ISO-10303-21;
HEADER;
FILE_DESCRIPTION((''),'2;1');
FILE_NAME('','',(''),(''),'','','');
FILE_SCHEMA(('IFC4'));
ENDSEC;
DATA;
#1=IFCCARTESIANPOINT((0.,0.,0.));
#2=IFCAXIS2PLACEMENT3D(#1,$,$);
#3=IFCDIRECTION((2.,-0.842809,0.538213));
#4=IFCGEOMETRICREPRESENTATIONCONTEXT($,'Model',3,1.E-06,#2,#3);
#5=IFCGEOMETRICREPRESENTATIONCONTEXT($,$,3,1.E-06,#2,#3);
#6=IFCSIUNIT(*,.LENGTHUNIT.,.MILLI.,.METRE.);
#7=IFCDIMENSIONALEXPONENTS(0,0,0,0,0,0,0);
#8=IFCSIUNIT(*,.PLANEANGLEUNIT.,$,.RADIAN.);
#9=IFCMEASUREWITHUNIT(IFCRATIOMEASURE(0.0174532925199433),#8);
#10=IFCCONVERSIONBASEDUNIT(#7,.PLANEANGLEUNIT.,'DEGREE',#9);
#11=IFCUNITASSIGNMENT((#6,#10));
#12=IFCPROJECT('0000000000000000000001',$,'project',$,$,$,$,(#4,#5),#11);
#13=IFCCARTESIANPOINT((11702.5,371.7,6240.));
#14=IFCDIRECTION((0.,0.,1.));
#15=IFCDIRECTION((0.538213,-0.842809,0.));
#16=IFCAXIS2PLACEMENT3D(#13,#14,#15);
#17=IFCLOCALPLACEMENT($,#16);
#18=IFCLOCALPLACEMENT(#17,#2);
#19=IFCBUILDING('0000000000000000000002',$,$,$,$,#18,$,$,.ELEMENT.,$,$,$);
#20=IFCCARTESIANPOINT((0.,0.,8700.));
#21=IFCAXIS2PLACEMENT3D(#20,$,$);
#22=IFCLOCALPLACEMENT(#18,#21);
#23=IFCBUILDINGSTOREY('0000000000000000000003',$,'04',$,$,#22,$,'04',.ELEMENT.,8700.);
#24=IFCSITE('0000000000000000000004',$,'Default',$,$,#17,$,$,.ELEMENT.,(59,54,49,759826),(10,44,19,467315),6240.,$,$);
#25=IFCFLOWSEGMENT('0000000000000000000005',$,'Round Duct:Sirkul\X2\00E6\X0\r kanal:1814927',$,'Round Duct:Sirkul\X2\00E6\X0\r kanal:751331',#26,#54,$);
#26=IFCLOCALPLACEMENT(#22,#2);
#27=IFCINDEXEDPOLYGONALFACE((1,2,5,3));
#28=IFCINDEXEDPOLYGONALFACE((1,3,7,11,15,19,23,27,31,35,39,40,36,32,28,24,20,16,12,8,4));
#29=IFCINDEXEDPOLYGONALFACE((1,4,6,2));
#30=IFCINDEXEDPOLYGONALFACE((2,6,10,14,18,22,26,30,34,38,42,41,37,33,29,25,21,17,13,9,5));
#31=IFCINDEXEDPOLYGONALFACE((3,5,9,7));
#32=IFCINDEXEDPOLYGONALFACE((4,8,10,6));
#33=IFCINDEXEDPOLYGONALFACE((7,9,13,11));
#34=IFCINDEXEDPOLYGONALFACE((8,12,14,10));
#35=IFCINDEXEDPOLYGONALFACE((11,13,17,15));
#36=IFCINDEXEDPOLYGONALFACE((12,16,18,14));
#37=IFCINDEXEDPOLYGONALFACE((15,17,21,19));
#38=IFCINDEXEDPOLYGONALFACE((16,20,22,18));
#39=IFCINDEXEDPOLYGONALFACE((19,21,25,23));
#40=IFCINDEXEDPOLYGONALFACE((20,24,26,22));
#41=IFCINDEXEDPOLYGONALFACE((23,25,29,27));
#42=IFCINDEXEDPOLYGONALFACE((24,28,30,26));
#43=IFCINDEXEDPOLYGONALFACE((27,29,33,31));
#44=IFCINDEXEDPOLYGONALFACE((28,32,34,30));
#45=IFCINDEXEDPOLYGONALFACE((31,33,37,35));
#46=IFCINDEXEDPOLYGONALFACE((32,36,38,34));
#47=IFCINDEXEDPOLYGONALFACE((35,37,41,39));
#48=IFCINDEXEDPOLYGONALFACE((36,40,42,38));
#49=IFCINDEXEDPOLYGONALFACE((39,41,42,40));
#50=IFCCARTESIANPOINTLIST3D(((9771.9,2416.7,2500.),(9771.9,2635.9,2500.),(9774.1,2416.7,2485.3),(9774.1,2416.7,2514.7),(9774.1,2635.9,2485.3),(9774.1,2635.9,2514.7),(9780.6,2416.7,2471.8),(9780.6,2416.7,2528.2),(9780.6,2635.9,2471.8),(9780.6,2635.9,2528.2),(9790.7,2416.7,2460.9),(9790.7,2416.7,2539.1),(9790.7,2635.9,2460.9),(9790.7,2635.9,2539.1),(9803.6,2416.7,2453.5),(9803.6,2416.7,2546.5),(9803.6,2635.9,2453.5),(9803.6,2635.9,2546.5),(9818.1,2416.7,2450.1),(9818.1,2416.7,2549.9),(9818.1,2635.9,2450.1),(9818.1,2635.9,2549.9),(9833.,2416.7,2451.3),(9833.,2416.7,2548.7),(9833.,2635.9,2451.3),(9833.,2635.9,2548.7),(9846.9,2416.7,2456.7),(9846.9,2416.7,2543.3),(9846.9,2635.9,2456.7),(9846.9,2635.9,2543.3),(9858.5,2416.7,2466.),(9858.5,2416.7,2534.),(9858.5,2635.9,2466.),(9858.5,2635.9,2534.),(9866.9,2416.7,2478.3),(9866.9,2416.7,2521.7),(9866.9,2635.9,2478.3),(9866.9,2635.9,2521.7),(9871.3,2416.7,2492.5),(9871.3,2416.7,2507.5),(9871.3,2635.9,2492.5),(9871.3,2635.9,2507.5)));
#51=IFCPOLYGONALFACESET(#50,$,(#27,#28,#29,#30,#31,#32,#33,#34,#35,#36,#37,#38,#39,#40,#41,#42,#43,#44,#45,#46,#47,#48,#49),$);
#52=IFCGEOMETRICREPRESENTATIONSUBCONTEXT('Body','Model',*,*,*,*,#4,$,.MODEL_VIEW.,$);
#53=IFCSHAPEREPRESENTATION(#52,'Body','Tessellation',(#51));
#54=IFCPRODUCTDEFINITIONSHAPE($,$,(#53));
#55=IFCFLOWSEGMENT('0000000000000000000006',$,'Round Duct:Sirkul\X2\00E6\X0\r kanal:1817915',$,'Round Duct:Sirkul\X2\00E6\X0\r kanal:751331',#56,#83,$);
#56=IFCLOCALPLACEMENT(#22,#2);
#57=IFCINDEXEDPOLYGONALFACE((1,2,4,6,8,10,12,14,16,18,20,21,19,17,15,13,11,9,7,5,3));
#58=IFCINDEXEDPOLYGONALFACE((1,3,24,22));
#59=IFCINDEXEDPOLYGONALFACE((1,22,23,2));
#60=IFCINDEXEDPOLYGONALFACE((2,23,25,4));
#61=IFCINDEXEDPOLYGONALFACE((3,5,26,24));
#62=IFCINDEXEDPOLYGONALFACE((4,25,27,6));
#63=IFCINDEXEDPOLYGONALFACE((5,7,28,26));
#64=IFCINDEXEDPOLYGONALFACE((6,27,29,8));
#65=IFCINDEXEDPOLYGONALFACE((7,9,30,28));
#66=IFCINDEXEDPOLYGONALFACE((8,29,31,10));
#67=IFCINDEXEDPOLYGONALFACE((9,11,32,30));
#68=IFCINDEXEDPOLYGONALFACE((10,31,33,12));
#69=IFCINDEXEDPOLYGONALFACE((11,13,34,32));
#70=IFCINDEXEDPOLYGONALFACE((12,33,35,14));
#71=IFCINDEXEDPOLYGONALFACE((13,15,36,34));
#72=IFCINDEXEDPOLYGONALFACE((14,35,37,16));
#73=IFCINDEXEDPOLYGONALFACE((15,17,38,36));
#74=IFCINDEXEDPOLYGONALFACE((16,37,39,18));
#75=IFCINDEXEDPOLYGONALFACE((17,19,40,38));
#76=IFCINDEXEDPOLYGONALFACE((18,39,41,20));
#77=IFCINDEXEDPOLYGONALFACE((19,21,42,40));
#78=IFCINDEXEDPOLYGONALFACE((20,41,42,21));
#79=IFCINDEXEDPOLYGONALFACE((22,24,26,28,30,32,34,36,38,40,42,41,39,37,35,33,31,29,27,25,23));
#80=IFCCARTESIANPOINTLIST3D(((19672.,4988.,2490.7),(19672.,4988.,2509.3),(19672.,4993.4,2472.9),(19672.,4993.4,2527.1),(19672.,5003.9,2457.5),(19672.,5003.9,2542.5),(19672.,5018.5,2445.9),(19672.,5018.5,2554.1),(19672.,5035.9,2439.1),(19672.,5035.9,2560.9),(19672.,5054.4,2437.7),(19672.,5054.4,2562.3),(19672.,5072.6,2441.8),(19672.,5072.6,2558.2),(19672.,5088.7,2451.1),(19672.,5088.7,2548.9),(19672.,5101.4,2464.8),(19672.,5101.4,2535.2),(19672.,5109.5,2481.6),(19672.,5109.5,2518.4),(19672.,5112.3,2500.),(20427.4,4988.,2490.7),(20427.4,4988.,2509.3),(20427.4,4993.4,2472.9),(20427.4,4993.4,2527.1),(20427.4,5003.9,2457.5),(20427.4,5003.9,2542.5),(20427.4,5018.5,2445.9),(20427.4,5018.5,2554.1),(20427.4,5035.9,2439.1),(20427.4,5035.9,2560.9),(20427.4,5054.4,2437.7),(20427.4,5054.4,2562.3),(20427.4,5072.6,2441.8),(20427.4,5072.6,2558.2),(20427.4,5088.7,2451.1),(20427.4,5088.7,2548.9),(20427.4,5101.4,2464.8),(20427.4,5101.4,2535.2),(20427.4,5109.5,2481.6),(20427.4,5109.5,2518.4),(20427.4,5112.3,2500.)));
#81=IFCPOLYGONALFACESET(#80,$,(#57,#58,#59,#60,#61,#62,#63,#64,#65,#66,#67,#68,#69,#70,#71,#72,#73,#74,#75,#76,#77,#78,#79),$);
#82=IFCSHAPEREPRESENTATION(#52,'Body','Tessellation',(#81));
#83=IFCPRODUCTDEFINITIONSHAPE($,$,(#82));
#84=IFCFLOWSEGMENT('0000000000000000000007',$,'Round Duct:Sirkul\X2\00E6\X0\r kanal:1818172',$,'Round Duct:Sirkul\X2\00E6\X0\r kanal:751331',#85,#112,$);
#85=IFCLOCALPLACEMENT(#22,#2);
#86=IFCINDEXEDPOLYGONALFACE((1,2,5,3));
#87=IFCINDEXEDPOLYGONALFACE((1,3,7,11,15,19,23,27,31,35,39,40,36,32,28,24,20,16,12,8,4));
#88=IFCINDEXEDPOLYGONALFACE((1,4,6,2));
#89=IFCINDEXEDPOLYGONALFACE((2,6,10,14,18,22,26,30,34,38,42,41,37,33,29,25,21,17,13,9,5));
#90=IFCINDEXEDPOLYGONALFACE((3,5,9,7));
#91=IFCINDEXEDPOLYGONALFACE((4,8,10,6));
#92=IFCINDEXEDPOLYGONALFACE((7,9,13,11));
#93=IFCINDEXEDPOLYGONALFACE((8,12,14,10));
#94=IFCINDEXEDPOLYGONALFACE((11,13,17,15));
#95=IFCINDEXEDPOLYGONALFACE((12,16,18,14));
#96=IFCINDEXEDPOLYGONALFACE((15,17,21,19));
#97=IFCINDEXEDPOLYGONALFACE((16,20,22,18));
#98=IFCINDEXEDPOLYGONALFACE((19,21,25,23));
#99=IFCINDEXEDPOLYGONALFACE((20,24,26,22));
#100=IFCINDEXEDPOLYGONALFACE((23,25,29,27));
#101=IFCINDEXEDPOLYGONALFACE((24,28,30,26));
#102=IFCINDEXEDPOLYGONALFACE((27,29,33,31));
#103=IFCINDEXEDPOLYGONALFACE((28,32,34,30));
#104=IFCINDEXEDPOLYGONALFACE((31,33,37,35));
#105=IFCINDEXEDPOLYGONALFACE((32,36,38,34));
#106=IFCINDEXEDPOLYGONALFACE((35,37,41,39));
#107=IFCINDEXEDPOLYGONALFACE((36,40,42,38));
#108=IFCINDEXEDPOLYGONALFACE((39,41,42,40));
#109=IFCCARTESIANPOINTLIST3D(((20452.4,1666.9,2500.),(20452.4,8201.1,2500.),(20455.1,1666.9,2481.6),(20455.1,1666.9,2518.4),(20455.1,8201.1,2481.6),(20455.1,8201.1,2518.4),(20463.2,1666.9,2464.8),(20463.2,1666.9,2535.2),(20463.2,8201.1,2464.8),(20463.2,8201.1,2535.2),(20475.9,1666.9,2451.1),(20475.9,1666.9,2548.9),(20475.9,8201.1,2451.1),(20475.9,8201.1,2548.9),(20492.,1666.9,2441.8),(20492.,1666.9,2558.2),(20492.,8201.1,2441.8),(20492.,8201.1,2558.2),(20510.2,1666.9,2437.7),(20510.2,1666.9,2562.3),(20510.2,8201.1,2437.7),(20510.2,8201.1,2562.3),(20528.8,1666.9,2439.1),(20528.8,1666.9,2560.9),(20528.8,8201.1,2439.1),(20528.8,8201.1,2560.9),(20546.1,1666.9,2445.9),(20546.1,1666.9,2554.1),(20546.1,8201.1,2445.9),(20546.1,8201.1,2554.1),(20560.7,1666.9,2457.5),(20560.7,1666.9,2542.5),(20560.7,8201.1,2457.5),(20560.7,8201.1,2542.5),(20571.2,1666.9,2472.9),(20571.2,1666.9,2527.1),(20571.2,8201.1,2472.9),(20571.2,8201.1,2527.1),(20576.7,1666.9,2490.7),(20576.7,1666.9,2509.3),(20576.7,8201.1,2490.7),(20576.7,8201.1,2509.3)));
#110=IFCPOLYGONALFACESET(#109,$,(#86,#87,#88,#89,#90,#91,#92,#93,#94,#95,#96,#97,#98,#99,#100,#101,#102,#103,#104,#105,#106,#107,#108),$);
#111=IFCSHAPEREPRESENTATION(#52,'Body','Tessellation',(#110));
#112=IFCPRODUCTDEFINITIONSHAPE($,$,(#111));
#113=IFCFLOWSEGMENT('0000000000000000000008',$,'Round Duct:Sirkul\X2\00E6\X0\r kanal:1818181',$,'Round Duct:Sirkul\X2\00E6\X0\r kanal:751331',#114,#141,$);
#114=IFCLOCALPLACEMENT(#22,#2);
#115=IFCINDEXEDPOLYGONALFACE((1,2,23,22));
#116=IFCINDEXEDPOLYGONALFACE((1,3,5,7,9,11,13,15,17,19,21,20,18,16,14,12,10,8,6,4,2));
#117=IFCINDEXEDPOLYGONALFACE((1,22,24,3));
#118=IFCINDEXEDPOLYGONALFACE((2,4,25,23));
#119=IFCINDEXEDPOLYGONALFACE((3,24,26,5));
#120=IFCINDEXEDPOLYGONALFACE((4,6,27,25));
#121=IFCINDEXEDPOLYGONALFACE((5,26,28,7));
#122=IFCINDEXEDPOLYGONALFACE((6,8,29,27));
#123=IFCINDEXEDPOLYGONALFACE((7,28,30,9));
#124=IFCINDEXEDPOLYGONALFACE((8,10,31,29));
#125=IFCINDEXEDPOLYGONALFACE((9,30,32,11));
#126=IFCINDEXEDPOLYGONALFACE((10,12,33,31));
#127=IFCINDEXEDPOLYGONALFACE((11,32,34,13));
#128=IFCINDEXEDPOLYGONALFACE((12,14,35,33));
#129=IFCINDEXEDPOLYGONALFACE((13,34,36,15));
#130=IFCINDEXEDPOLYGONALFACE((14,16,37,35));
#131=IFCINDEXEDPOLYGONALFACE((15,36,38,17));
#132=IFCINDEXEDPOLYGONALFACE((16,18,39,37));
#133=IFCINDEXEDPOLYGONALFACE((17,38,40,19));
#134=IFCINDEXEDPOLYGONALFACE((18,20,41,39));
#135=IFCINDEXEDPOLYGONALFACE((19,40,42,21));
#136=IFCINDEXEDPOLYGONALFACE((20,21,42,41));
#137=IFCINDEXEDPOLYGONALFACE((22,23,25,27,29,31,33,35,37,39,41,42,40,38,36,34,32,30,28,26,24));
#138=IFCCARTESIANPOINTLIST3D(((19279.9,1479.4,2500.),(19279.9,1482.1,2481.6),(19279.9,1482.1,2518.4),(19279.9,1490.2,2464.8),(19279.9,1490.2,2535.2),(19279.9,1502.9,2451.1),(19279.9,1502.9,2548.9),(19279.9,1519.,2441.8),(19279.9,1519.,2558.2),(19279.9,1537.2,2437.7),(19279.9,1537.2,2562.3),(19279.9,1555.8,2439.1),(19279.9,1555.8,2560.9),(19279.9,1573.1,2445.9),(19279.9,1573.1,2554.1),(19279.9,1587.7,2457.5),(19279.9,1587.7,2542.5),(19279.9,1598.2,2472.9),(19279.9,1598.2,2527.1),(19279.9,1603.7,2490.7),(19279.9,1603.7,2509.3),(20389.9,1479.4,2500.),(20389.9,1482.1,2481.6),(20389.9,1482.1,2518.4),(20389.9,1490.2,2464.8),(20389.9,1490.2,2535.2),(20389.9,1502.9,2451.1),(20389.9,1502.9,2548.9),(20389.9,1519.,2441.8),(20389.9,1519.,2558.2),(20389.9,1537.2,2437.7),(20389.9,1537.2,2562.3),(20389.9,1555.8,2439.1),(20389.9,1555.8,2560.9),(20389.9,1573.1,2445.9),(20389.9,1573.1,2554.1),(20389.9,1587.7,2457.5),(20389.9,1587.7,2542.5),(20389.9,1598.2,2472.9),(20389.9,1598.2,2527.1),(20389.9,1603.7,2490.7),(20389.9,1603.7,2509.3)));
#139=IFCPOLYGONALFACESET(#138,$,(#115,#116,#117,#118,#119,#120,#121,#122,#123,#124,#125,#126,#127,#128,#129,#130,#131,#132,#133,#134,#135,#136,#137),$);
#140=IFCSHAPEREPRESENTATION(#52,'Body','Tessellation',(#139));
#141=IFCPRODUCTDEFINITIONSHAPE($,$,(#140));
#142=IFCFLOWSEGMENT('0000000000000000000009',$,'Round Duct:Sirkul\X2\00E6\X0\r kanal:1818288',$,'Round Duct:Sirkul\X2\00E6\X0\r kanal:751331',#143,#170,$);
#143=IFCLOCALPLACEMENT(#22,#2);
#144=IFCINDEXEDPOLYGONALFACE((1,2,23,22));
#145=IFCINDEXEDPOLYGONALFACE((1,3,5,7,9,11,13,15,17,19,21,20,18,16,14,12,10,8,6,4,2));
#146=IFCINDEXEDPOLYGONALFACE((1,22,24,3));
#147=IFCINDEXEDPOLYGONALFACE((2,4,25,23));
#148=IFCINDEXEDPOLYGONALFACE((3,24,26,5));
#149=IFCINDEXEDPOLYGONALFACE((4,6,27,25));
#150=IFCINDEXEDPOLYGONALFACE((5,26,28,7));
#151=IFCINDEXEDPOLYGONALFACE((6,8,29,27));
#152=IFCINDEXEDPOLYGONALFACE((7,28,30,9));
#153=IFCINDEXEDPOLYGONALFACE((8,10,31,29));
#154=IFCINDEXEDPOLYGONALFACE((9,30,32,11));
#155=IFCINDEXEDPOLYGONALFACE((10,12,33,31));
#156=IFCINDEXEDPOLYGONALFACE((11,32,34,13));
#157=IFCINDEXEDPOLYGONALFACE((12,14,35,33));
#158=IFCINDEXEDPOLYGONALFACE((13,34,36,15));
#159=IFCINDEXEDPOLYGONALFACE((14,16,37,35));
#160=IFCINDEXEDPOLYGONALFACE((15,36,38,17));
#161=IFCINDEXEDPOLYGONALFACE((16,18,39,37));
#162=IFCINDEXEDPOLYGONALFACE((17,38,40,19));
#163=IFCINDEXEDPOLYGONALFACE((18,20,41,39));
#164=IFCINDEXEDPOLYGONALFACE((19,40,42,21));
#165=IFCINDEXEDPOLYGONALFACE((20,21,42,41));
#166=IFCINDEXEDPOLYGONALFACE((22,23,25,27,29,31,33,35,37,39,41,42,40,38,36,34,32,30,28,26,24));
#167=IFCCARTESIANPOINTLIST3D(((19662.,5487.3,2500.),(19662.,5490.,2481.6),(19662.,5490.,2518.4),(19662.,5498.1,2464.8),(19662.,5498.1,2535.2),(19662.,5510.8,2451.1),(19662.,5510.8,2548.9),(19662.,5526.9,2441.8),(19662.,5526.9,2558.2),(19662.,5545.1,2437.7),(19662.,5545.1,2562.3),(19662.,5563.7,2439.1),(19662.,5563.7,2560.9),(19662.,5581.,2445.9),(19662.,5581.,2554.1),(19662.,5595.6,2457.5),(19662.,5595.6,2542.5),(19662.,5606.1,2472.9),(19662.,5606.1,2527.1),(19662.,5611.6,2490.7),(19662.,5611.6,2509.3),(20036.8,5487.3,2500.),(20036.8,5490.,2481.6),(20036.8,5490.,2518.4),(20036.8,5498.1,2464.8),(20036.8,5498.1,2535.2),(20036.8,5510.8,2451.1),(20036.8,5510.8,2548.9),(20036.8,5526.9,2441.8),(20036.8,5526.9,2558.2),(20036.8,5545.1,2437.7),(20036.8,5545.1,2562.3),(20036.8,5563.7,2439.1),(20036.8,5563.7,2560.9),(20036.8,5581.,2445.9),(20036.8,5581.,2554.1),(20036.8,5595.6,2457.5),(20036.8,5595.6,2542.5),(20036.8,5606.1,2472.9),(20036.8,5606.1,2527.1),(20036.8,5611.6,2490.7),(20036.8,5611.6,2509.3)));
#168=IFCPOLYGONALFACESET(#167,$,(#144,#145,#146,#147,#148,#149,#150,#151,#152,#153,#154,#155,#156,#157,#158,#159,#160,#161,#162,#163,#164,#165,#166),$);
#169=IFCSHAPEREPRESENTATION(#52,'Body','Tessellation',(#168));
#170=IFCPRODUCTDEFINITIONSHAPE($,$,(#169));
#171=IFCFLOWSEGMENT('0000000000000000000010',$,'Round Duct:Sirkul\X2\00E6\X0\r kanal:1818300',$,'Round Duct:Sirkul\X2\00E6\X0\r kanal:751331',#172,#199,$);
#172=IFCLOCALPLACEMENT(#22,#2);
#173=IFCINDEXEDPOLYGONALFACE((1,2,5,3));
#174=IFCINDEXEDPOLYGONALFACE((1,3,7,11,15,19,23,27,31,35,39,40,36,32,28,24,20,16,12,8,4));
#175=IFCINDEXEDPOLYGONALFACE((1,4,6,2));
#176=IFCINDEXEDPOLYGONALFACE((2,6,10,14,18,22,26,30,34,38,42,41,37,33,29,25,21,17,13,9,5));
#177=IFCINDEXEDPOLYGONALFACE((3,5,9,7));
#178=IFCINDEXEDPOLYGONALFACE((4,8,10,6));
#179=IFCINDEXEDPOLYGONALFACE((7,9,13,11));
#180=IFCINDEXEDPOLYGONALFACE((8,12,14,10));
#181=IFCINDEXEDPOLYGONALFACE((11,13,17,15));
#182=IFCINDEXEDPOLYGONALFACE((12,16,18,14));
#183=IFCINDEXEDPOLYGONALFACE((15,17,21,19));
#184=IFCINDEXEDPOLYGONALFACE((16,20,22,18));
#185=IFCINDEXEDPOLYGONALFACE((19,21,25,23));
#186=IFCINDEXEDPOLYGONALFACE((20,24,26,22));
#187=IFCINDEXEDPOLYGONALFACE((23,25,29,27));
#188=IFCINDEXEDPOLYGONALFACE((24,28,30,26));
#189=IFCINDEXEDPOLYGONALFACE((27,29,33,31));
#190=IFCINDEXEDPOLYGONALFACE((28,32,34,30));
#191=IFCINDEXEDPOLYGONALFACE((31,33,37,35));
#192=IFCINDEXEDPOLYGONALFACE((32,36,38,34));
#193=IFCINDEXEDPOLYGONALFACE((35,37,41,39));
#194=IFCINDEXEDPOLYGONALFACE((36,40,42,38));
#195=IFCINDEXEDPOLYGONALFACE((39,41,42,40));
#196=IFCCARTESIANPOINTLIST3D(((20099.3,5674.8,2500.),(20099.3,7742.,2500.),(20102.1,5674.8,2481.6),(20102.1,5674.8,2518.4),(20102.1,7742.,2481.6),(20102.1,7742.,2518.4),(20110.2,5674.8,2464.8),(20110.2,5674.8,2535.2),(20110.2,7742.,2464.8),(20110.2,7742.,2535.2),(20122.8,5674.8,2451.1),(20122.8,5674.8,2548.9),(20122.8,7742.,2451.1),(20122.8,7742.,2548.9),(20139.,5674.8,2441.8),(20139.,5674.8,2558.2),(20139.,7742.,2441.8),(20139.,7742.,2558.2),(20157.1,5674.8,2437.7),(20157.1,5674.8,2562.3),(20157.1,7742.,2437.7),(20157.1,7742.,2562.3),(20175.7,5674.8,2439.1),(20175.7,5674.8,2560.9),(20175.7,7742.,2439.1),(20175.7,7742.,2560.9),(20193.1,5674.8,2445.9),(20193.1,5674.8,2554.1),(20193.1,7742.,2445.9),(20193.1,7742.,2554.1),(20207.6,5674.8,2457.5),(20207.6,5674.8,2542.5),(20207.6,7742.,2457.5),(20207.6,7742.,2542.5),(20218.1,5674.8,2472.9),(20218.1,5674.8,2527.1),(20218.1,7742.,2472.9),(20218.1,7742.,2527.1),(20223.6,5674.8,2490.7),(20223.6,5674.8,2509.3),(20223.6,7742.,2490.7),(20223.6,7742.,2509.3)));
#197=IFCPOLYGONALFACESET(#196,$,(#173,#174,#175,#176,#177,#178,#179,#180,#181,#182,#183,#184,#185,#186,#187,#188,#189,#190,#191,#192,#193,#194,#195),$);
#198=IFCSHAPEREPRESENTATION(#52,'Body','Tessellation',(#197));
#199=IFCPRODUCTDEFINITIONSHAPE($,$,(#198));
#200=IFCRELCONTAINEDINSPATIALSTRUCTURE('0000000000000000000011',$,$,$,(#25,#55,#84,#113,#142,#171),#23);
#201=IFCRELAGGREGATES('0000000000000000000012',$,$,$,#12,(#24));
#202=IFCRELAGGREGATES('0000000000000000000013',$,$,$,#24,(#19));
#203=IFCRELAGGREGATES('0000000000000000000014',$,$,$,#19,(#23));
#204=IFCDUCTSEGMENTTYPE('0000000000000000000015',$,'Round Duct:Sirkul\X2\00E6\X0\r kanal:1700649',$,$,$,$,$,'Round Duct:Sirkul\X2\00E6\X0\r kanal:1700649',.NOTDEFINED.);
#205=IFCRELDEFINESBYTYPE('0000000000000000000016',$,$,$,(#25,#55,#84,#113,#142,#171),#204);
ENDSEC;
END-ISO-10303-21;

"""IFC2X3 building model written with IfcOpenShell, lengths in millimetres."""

from ifc_helpers import new_model, entity, si_unit, converted_unit, direction, frame, frame_2d, origin, origin_2d_with_axis, place, context, subcontext, project, spatial, circle, extrude, type_object, element, save


model = new_model("IFC2X3")

# Units and contexts
model_context = context("Model", 3, precision=1e-06, world=origin(), true_north=direction((2.0, -0.842809, 0.538213)))
context_of_model = context(None, 3, precision=1e-06, world=origin(), true_north=direction((2.0, -0.842809, 0.538213)))
body_context = subcontext(model_context, "Body", "Model", "MODEL_VIEW")
ifc_project = project(units=[si_unit("LENGTHUNIT", "METRE", prefix="MILLI"), converted_unit("PLANEANGLEUNIT", "DEGREE", entity("IfcRatioMeasure", 0.0174532925199433), si_unit("PLANEANGLEUNIT", "RADIAN"), dimensions=[0, 0, 0, 0, 0, 0, 0])], contexts=[model_context, context_of_model])

# Site, building, storey
site_placement = place(None, frame((11702.5, 371.7, 6240.0), z_axis=(0.0, 0.0, 1.0), x_axis=(0.538213, -0.842809, 0.0)))
site = spatial("IfcSite", under=ifc_project, at=site_placement, Name="Default", CompositionType="ELEMENT", RefLatitude=(59, 54, 49, 759826), RefLongitude=(10, 44, 19, 467315), RefElevation=6240.0)
building_placement = place(site_placement, origin())
building = spatial("IfcBuilding", under=site, at=building_placement, CompositionType="ELEMENT")
storey_placement = place(building_placement, frame((0.0, 0.0, 8700.0)))
storey = spatial("IfcBuildingStorey", under=building, at=storey_placement, Name="04", LongName="04", CompositionType="ELEMENT", Elevation=8700.0)

# Flow segments
duct_segment_type_1 = type_object("IfcDuctSegmentType", Name="Round Duct:Sirkulær kanal:1700649", ElementType="Round Duct:Sirkulær kanal:1700649", PredefinedType="NOTDEFINED")
flow_segment_1_placement = place(storey_placement, origin())
element("IfcFlowSegment", 1, at=flow_segment_1_placement, inside=storey, type_object=duct_segment_type_1, Name="Round Duct:Sirkulær kanal:1814927", ObjectType="Round Duct:Sirkulær kanal:751331", context=body_context, shape_type="SweptSolid", body=[
    extrude(circle(Radius=50.0, at=origin_2d_with_axis()), frame((9821.9, 2416.7, 2500.0), z_axis=(0.0, 1.0, 0.0), x_axis=(-1.0, 0.0, 0.0)), (0.0, 0.0, 1.0), 219.2),
])
flow_segment_2_placement = place(storey_placement, origin())
element("IfcFlowSegment", 2, at=flow_segment_2_placement, inside=storey, type_object=duct_segment_type_1, Name="Round Duct:Sirkulær kanal:1817915", ObjectType="Round Duct:Sirkulær kanal:751331", context=body_context, shape_type="SweptSolid", body=[
    extrude(circle(Radius=62.5, at=frame_2d((0.0, 0.0), x_axis=(1.0, 0.0))), frame((19672.0, 5049.8, 2500.0), z_axis=(1.0, 0.0, 0.0), x_axis=(0.0, 1.0, 0.0)), (0.0, 0.0, 1.0), 755.3),
])
flow_segment_3_placement = place(storey_placement, origin())
element("IfcFlowSegment", 3, at=flow_segment_3_placement, inside=storey, type_object=duct_segment_type_1, Name="Round Duct:Sirkulær kanal:1818172", ObjectType="Round Duct:Sirkulær kanal:751331", context=body_context, shape_type="SweptSolid", body=[
    extrude(circle(Radius=62.5, at=frame_2d((0.0, 0.0), x_axis=(1.0, 0.0))), frame((20514.9, 1666.9, 2500.0), z_axis=(0.0, 1.0, 0.0), x_axis=(-1.0, 0.0, 0.0)), (0.0, 0.0, 1.0), 6534.2),
])
flow_segment_4_placement = place(storey_placement, origin())
element("IfcFlowSegment", 4, at=flow_segment_4_placement, inside=storey, type_object=duct_segment_type_1, Name="Round Duct:Sirkulær kanal:1818181", ObjectType="Round Duct:Sirkulær kanal:751331", context=body_context, shape_type="SweptSolid", body=[
    extrude(circle(Radius=62.5, at=origin_2d_with_axis()), frame((19279.9, 1541.9, 2500.0), z_axis=(1.0, 0.0, 0.0), x_axis=(0.0, -1.0, 0.0)), (0.0, 0.0, 1.0), 1109.9),
])
flow_segment_5_placement = place(storey_placement, origin())
element("IfcFlowSegment", 5, at=flow_segment_5_placement, inside=storey, type_object=duct_segment_type_1, Name="Round Duct:Sirkulær kanal:1818288", ObjectType="Round Duct:Sirkulær kanal:751331", context=body_context, shape_type="SweptSolid", body=[
    extrude(circle(Radius=62.5, at=origin_2d_with_axis()), frame((19662.0, 5549.8, 2500.0), z_axis=(1.0, 0.0, 0.0), x_axis=(0.0, -1.0, 0.0)), (0.0, 0.0, 1.0), 374.8),
])
flow_segment_6_placement = place(storey_placement, origin())
element("IfcFlowSegment", 6, at=flow_segment_6_placement, inside=storey, type_object=duct_segment_type_1, Name="Round Duct:Sirkulær kanal:1818300", ObjectType="Round Duct:Sirkulær kanal:751331", context=body_context, shape_type="SweptSolid", body=[
    extrude(circle(Radius=62.5, at=frame_2d((0.0, 0.0), x_axis=(1.0, 0.0))), frame((20161.8, 5674.8, 2500.0), z_axis=(0.0, 1.0, 0.0), x_axis=(-1.0, 0.0, 0.0)), (0.0, 0.0, 1.0), 2067.3),
])

save(model, "model.ifc")
